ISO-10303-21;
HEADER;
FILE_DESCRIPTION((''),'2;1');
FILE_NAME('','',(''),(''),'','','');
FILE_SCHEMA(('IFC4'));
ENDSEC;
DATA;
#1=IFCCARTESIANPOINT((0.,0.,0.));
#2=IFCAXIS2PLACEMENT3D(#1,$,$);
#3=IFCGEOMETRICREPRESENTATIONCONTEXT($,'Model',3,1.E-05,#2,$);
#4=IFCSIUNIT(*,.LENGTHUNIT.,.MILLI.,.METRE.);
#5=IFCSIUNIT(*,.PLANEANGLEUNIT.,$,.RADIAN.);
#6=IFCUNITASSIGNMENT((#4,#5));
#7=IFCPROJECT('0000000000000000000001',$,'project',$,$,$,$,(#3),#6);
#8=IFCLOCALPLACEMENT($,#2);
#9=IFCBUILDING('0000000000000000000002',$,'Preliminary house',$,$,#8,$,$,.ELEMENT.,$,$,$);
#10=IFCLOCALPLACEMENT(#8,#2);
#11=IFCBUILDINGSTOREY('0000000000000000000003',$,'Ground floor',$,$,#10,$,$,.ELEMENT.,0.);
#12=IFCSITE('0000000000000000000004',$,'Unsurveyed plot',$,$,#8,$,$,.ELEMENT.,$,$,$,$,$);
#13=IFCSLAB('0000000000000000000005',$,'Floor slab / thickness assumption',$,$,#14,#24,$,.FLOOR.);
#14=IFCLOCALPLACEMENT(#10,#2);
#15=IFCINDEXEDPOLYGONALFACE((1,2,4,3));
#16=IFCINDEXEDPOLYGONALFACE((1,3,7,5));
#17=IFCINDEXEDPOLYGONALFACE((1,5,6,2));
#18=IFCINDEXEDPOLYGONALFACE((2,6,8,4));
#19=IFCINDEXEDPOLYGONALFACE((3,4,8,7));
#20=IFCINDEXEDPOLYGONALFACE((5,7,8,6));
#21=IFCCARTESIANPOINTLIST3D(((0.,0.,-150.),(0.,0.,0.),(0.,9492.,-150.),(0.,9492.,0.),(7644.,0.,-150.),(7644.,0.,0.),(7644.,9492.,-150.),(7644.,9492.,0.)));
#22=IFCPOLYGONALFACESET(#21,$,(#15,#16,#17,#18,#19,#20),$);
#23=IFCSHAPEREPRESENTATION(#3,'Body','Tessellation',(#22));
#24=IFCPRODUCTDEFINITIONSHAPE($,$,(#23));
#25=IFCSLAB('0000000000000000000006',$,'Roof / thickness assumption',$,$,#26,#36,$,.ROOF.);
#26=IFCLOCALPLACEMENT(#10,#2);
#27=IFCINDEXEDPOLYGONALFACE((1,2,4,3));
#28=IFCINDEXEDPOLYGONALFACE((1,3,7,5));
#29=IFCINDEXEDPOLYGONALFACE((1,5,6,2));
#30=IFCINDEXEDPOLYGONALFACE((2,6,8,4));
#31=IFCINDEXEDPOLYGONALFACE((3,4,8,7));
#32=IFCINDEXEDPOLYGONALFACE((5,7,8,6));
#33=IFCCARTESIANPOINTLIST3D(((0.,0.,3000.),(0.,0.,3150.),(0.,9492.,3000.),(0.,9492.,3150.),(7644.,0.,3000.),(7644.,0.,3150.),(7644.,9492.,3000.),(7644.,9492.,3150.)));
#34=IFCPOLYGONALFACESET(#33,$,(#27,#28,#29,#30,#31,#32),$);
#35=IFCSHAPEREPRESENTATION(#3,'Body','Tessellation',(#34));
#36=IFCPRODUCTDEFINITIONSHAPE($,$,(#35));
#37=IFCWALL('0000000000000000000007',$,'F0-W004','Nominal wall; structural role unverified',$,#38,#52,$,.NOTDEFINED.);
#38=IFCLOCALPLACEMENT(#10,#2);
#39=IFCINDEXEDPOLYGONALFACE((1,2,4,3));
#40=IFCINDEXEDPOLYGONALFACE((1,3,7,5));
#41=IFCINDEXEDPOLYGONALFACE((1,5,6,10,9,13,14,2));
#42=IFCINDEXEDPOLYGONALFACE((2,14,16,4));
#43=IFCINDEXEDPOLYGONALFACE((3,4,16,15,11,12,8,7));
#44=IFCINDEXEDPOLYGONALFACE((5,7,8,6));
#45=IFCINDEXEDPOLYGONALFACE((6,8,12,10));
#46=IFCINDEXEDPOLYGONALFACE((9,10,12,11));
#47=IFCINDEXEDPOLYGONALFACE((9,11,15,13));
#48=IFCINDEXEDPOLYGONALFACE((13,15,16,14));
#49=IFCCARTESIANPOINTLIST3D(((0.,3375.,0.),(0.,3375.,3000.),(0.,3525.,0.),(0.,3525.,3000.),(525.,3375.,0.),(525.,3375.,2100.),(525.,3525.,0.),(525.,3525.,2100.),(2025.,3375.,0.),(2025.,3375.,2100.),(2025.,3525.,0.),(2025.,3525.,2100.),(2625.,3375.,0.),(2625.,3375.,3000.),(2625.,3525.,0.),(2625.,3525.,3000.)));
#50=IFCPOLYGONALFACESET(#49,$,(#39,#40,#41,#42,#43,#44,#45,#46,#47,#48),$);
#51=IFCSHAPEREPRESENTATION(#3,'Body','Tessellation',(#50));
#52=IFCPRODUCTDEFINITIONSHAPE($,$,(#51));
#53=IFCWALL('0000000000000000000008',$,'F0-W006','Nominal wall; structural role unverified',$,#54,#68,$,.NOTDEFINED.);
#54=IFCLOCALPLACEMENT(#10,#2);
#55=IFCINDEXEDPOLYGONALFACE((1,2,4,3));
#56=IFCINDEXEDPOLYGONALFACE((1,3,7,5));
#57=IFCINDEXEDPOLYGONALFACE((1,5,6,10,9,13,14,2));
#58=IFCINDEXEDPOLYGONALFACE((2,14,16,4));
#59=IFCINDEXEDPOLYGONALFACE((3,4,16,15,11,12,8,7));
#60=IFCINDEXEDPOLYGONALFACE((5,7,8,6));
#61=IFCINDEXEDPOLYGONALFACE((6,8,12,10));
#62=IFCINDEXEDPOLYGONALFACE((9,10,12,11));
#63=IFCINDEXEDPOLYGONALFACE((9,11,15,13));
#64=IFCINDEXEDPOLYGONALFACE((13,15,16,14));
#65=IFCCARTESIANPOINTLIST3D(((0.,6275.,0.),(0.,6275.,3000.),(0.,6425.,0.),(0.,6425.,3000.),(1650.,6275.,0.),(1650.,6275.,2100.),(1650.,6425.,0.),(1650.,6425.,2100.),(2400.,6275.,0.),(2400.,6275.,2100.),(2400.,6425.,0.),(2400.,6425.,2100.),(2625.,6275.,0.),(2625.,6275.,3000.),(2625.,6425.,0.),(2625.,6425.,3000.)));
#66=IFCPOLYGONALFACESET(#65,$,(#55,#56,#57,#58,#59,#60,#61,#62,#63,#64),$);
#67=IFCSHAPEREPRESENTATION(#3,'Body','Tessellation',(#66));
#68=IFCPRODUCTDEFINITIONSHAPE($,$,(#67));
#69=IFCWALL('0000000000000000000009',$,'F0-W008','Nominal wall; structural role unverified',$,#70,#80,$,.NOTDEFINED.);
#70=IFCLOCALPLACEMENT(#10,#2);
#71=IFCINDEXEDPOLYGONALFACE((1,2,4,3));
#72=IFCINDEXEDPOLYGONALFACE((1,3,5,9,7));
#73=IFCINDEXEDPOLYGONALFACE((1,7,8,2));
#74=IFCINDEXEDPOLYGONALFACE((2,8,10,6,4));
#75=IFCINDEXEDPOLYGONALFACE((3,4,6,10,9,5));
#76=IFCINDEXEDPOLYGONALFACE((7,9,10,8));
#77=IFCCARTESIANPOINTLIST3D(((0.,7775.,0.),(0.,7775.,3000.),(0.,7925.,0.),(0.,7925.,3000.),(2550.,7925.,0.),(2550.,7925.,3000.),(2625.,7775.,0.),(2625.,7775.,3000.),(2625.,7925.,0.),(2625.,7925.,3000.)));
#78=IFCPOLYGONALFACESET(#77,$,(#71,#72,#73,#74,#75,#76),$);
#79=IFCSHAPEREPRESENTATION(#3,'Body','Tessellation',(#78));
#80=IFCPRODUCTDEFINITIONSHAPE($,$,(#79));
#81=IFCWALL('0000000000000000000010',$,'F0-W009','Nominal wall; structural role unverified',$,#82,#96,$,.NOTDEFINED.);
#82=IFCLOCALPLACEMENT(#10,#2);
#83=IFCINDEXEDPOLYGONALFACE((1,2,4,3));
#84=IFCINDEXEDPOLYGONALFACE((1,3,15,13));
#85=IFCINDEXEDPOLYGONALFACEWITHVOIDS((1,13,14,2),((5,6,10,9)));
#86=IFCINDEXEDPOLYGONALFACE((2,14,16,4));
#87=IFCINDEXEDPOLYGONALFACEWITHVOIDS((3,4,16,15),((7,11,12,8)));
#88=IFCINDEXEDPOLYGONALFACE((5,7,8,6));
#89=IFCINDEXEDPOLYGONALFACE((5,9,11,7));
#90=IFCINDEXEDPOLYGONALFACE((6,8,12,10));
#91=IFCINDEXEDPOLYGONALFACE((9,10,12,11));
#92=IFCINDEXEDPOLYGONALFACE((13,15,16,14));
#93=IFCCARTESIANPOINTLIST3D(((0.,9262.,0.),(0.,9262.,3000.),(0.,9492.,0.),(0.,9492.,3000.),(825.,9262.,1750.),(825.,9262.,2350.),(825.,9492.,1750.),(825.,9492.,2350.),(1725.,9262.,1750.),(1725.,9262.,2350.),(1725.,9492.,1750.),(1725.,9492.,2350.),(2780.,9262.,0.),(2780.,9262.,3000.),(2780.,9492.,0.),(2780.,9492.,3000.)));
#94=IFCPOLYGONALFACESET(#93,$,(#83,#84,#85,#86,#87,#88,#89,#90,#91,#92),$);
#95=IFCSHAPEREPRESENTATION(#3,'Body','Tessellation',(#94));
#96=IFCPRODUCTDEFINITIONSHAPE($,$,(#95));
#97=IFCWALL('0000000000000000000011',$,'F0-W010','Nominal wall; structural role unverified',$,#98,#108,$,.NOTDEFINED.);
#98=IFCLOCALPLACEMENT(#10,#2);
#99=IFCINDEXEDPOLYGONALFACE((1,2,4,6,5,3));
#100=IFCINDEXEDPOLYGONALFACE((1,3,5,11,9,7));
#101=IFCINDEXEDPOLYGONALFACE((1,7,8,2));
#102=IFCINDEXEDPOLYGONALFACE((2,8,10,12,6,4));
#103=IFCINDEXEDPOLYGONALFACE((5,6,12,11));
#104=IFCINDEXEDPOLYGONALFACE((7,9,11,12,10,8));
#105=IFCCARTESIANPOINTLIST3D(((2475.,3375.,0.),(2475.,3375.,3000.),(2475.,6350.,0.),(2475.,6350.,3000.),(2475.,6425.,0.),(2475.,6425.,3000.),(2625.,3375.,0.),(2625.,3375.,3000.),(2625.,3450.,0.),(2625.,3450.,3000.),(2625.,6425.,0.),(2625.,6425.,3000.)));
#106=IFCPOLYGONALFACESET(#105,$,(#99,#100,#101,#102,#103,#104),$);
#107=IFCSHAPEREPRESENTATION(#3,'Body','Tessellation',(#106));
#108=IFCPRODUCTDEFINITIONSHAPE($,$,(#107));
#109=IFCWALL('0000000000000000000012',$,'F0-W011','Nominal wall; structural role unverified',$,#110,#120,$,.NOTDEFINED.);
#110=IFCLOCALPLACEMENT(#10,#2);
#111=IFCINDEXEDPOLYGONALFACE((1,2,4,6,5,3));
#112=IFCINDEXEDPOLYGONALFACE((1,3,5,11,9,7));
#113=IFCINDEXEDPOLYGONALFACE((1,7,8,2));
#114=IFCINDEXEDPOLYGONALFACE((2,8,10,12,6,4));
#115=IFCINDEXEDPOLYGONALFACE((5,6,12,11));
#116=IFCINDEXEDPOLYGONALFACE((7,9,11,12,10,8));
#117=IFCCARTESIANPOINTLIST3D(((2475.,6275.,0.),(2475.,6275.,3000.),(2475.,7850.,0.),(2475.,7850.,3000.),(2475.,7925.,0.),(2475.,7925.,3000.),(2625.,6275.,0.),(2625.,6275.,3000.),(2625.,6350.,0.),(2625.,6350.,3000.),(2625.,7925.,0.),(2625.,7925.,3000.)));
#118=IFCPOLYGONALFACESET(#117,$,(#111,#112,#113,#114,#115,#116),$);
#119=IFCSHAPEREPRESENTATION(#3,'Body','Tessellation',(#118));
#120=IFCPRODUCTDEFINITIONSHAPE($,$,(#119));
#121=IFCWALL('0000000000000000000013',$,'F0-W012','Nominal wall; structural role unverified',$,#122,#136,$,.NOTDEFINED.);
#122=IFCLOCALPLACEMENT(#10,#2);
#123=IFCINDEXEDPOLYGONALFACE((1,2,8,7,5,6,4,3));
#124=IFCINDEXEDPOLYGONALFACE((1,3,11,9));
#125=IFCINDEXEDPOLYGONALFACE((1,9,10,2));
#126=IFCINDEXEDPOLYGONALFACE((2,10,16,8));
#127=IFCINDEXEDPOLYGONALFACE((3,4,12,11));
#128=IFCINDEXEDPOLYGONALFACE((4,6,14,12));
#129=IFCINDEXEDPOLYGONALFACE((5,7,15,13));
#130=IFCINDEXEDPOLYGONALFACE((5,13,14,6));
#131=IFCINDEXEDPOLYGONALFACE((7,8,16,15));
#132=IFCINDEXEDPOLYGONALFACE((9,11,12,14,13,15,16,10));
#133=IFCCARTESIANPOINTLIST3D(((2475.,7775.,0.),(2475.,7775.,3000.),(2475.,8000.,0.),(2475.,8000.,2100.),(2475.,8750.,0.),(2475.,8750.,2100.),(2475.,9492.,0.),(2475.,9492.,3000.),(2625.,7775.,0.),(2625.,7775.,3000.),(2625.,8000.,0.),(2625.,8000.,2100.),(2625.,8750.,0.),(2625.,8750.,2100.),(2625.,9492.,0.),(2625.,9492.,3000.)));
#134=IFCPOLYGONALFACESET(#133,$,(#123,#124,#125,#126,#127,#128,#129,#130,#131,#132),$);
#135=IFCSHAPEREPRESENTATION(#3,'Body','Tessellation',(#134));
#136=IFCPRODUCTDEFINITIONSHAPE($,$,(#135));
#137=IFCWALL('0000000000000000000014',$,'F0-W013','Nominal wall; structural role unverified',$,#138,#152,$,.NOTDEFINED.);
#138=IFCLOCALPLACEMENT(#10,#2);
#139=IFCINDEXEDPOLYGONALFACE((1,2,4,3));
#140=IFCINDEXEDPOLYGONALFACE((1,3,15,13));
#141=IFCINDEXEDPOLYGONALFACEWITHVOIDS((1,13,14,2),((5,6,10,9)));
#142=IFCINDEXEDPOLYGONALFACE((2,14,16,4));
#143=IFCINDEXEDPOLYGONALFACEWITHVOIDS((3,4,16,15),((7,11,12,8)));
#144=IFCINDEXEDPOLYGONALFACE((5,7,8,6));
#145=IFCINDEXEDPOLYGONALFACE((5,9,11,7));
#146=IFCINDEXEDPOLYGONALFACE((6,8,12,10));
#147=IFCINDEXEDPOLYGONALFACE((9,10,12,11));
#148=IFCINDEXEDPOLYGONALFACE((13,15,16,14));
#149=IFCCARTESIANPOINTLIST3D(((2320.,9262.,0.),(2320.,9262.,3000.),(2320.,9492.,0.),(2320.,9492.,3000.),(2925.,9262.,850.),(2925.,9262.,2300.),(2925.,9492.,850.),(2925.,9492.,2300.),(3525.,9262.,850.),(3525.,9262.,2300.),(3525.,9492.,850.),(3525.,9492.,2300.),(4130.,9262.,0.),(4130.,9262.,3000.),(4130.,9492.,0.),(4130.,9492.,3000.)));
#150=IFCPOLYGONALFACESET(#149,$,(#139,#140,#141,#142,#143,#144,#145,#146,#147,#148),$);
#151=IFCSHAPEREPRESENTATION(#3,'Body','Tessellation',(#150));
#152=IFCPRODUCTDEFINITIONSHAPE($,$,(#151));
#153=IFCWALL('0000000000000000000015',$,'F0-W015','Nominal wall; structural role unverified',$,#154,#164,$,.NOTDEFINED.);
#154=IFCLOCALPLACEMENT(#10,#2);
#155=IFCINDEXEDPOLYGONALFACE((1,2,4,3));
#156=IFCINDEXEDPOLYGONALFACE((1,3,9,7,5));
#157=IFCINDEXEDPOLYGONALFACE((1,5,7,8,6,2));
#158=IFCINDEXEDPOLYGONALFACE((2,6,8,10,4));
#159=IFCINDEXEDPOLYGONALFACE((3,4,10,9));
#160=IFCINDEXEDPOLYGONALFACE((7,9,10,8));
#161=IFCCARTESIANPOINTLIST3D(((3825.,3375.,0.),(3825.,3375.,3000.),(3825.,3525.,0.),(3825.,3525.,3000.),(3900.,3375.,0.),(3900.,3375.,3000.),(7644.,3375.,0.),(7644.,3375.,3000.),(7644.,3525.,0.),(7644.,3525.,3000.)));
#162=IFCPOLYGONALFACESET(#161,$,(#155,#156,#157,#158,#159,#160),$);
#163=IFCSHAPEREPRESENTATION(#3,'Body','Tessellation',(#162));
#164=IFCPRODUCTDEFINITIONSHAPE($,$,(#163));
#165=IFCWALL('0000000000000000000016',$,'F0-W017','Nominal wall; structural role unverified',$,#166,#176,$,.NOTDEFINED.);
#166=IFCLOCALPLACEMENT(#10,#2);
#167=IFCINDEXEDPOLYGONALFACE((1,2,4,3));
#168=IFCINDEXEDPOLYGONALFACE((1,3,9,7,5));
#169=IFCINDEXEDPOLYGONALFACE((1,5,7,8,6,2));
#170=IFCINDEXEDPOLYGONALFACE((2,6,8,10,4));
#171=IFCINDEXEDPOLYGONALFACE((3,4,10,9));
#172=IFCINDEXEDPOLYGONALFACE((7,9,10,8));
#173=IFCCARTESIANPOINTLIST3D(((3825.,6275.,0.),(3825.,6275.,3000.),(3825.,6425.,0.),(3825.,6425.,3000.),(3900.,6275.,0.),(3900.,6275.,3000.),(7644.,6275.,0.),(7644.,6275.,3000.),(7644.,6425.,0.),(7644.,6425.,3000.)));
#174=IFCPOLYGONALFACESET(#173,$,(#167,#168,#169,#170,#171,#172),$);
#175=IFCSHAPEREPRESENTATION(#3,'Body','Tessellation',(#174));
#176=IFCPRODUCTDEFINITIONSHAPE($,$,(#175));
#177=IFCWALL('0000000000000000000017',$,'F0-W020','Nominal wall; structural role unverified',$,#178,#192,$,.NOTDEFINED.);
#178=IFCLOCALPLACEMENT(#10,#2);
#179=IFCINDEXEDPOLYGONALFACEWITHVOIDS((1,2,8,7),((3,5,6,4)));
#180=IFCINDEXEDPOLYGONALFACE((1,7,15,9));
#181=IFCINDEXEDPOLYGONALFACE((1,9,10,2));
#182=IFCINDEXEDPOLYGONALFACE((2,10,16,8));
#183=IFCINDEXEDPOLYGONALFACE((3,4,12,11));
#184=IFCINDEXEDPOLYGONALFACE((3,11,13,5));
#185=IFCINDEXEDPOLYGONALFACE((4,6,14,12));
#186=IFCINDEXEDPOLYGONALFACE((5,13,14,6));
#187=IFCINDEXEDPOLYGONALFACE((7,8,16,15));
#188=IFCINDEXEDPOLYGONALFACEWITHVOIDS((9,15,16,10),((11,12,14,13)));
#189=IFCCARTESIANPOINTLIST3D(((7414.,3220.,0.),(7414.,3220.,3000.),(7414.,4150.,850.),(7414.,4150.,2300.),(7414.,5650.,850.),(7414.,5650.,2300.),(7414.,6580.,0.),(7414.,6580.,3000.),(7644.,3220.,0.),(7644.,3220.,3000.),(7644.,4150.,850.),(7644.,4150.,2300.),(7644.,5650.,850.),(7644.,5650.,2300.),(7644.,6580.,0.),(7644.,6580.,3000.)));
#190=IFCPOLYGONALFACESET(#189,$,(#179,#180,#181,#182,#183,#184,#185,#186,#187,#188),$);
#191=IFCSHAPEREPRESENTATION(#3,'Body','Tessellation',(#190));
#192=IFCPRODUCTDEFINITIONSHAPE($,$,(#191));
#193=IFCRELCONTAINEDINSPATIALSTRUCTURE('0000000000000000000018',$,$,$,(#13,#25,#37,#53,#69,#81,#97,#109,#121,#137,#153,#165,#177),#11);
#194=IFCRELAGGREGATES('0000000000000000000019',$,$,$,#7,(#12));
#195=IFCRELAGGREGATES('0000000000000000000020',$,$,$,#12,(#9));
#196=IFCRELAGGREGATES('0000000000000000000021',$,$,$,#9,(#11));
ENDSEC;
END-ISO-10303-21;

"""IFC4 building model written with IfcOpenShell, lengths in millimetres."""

from ifc_helpers import new_model, si_unit, frame, origin, place, context, project, spatial, polyline, outline, extrude, element, save


model = new_model("IFC4")

# Units and contexts
model_context = context("Model", 3, precision=1e-05, world=origin())
ifc_project = project(units=[si_unit("LENGTHUNIT", "METRE", prefix="MILLI"), si_unit("PLANEANGLEUNIT", "RADIAN")], contexts=[model_context])

# Site, building, storey
placement_1 = place(None, origin())
site = spatial("IfcSite", under=ifc_project, at=placement_1, Name="Unsurveyed plot", CompositionType="ELEMENT")
building = spatial("IfcBuilding", under=site, at=placement_1, Name="Preliminary house", CompositionType="ELEMENT")
placement_2 = place(placement_1, origin())
storey = spatial("IfcBuildingStorey", under=building, at=placement_2, Name="Ground floor", CompositionType="ELEMENT", Elevation=0.0)

# Slabs
element("IfcSlab", 1, at=placement_2, inside=storey, Name="Floor slab / thickness assumption", PredefinedType="FLOOR", context=model_context, shape_type="SweptSolid", body=[
    extrude(outline(polyline([(7644.0, 0.0), (7644.0, 9492.0), (0.0, 9492.0), (0.0, 0.0), (7644.0, 0.0)])), frame((0.0, 0.0, -150.0)), (0.0, 0.0, 1.0), 150.0),
])
element("IfcSlab", 2, at=placement_2, inside=storey, Name="Roof / thickness assumption", PredefinedType="ROOF", context=model_context, shape_type="SweptSolid", body=[
    extrude(outline(polyline([(7644.0, 0.0), (7644.0, 9492.0), (0.0, 9492.0), (0.0, 0.0), (7644.0, 0.0)])), frame((0.0, 0.0, 3000.0)), (0.0, 0.0, 1.0), 150.0),
])

# Walls, openings
wall_1 = element("IfcWall", 3, at=placement_2, inside=storey, Name="F0-W004", Description="Nominal wall; structural role unverified", PredefinedType="NOTDEFINED", context=model_context, shape_type="SweptSolid", body=[
    extrude(outline(polyline([(2625.0, 3525.0), (2625.0, 3375.0), (0.0, 3375.0), (0.0, 3525.0), (2550.0, 3525.0), (2625.0, 3525.0)])), origin(), (0.0, 0.0, 1.0), 3000.0),
])
element("IfcOpeningElement", 4, at=placement_2, cuts=wall_1, PredefinedType="OPENING", context=model_context, shape_type="SweptSolid", body=[
    extrude(outline(polyline([(525.0, 3000.0), (2025.0, 3000.0), (2025.0, 3900.0), (525.0, 3900.0), (525.0, 3000.0)])), origin(), (0.0, 0.0, 1.0), 2100.0),
])
wall_2 = element("IfcWall", 5, at=placement_2, inside=storey, Name="F0-W006", Description="Nominal wall; structural role unverified", PredefinedType="NOTDEFINED", context=model_context, shape_type="SweptSolid", body=[
    extrude(outline(polyline([(2625.0, 6425.0), (2625.0, 6275.0), (0.0, 6275.0), (0.0, 6425.0), (2550.0, 6425.0), (2625.0, 6425.0)])), origin(), (0.0, 0.0, 1.0), 3000.0),
])
element("IfcOpeningElement", 6, at=placement_2, cuts=wall_2, PredefinedType="OPENING", context=model_context, shape_type="SweptSolid", body=[
    extrude(outline(polyline([(1650.0, 5900.0), (2400.0, 5900.0), (2400.0, 6800.0), (1650.0, 6800.0), (1650.0, 5900.0)])), origin(), (0.0, 0.0, 1.0), 2100.0),
])

# Wall
element("IfcWall", 7, at=placement_2, inside=storey, Name="F0-W008", Description="Nominal wall; structural role unverified", PredefinedType="NOTDEFINED", context=model_context, shape_type="SweptSolid", body=[
    extrude(outline(polyline([(2625.0, 7925.0), (2625.0, 7775.0), (0.0, 7775.0), (0.0, 7925.0), (2550.0, 7925.0), (2625.0, 7925.0)])), origin(), (0.0, 0.0, 1.0), 3000.0),
])

# Wall, opening
wall_3 = element("IfcWall", 8, at=placement_2, inside=storey, Name="F0-W009", Description="Nominal wall; structural role unverified", PredefinedType="NOTDEFINED", context=model_context, shape_type="SweptSolid", body=[
    extrude(outline(polyline([(2780.0, 9262.0), (0.0, 9262.0), (0.0, 9492.0), (2780.0, 9492.0), (2780.0, 9262.0)])), origin(), (0.0, 0.0, 1.0), 3000.0),
])
element("IfcOpeningElement", 9, at=placement_2, cuts=wall_3, PredefinedType="OPENING", context=model_context, shape_type="SweptSolid", body=[
    extrude(outline(polyline([(825.0, 8847.0), (1725.0, 8847.0), (1725.0, 9907.0), (825.0, 9907.0), (825.0, 8847.0)])), frame((0.0, 0.0, 1750.0)), (0.0, 0.0, 1.0), 600.0),
])

# Walls
element("IfcWall", 10, at=placement_2, inside=storey, Name="F0-W010", Description="Nominal wall; structural role unverified", PredefinedType="NOTDEFINED", context=model_context, shape_type="SweptSolid", body=[
    extrude(outline(polyline([(2475.0, 6425.0), (2625.0, 6425.0), (2625.0, 3450.0), (2625.0, 3375.0), (2475.0, 3375.0), (2475.0, 6350.0), (2475.0, 6425.0)])), origin(), (0.0, 0.0, 1.0), 3000.0),
])
element("IfcWall", 11, at=placement_2, inside=storey, Name="F0-W011", Description="Nominal wall; structural role unverified", PredefinedType="NOTDEFINED", context=model_context, shape_type="SweptSolid", body=[
    extrude(outline(polyline([(2475.0, 7925.0), (2625.0, 7925.0), (2625.0, 6350.0), (2625.0, 6275.0), (2475.0, 6275.0), (2475.0, 7850.0), (2475.0, 7925.0)])), origin(), (0.0, 0.0, 1.0), 3000.0),
])

# Walls, openings
wall_4 = element("IfcWall", 12, at=placement_2, inside=storey, Name="F0-W012", Description="Nominal wall; structural role unverified", PredefinedType="NOTDEFINED", context=model_context, shape_type="SweptSolid", body=[
    extrude(outline(polyline([(2625.0, 7850.0), (2625.0, 7775.0), (2475.0, 7775.0), (2475.0, 9492.0), (2625.0, 9492.0), (2625.0, 7850.0)])), origin(), (0.0, 0.0, 1.0), 3000.0),
])
element("IfcOpeningElement", 13, at=placement_2, cuts=wall_4, PredefinedType="OPENING", context=model_context, shape_type="SweptSolid", body=[
    extrude(outline(polyline([(3000.0, 8000.0), (3000.0, 8750.0), (2100.0, 8750.0), (2100.0, 8000.0), (3000.0, 8000.0)])), origin(), (0.0, 0.0, 1.0), 2100.0),
])
wall_5 = element("IfcWall", 14, at=placement_2, inside=storey, Name="F0-W013", Description="Nominal wall; structural role unverified", PredefinedType="NOTDEFINED", context=model_context, shape_type="SweptSolid", body=[
    extrude(outline(polyline([(4130.0, 9262.0), (2550.0, 9262.0), (2320.0, 9262.0), (2320.0, 9492.0), (4130.0, 9492.0), (4130.0, 9262.0)])), origin(), (0.0, 0.0, 1.0), 3000.0),
])
element("IfcOpeningElement", 15, at=placement_2, cuts=wall_5, PredefinedType="OPENING", context=model_context, shape_type="SweptSolid", body=[
    extrude(outline(polyline([(2925.0, 8847.0), (3525.0, 8847.0), (3525.0, 9907.0), (2925.0, 9907.0), (2925.0, 8847.0)])), frame((0.0, 0.0, 850.0)), (0.0, 0.0, 1.0), 1450.0),
])

# Wall
element("IfcWall", 16, at=placement_2, inside=storey, Name="F0-W015", Description="Nominal wall; structural role unverified", PredefinedType="NOTDEFINED", context=model_context, shape_type="SweptSolid", body=[
    extrude(outline(polyline([(3900.0, 3375.0), (3825.0, 3375.0), (3825.0, 3525.0), (7644.0, 3525.0), (7644.0, 3375.0), (3900.0, 3375.0)])), origin(), (0.0, 0.0, 1.0), 3000.0),
])

# Wall
element("IfcWall", 17, at=placement_2, inside=storey, Name="F0-W017", Description="Nominal wall; structural role unverified", PredefinedType="NOTDEFINED", context=model_context, shape_type="SweptSolid", body=[
    extrude(outline(polyline([(3900.0, 6275.0), (3825.0, 6275.0), (3825.0, 6425.0), (7644.0, 6425.0), (7644.0, 6275.0), (3900.0, 6275.0)])), origin(), (0.0, 0.0, 1.0), 3000.0),
])

# Wall, opening
wall_6 = element("IfcWall", 18, at=placement_2, inside=storey, Name="F0-W020", Description="Nominal wall; structural role unverified", PredefinedType="NOTDEFINED", context=model_context, shape_type="SweptSolid", body=[
    extrude(outline(polyline([(7414.0, 6580.0), (7644.0, 6580.0), (7644.0, 3220.0), (7414.0, 3220.0), (7414.0, 6350.0), (7414.0, 6580.0)])), origin(), (0.0, 0.0, 1.0), 3000.0),
])
element("IfcOpeningElement", 19, at=placement_2, cuts=wall_6, PredefinedType="OPENING", context=model_context, shape_type="SweptSolid", body=[
    extrude(outline(polyline([(8059.0, 4150.0), (8059.0, 5650.0), (6999.0, 5650.0), (6999.0, 4150.0), (8059.0, 4150.0)])), frame((0.0, 0.0, 850.0)), (0.0, 0.0, 1.0), 1450.0),
])

save(model, "model.ifc")
